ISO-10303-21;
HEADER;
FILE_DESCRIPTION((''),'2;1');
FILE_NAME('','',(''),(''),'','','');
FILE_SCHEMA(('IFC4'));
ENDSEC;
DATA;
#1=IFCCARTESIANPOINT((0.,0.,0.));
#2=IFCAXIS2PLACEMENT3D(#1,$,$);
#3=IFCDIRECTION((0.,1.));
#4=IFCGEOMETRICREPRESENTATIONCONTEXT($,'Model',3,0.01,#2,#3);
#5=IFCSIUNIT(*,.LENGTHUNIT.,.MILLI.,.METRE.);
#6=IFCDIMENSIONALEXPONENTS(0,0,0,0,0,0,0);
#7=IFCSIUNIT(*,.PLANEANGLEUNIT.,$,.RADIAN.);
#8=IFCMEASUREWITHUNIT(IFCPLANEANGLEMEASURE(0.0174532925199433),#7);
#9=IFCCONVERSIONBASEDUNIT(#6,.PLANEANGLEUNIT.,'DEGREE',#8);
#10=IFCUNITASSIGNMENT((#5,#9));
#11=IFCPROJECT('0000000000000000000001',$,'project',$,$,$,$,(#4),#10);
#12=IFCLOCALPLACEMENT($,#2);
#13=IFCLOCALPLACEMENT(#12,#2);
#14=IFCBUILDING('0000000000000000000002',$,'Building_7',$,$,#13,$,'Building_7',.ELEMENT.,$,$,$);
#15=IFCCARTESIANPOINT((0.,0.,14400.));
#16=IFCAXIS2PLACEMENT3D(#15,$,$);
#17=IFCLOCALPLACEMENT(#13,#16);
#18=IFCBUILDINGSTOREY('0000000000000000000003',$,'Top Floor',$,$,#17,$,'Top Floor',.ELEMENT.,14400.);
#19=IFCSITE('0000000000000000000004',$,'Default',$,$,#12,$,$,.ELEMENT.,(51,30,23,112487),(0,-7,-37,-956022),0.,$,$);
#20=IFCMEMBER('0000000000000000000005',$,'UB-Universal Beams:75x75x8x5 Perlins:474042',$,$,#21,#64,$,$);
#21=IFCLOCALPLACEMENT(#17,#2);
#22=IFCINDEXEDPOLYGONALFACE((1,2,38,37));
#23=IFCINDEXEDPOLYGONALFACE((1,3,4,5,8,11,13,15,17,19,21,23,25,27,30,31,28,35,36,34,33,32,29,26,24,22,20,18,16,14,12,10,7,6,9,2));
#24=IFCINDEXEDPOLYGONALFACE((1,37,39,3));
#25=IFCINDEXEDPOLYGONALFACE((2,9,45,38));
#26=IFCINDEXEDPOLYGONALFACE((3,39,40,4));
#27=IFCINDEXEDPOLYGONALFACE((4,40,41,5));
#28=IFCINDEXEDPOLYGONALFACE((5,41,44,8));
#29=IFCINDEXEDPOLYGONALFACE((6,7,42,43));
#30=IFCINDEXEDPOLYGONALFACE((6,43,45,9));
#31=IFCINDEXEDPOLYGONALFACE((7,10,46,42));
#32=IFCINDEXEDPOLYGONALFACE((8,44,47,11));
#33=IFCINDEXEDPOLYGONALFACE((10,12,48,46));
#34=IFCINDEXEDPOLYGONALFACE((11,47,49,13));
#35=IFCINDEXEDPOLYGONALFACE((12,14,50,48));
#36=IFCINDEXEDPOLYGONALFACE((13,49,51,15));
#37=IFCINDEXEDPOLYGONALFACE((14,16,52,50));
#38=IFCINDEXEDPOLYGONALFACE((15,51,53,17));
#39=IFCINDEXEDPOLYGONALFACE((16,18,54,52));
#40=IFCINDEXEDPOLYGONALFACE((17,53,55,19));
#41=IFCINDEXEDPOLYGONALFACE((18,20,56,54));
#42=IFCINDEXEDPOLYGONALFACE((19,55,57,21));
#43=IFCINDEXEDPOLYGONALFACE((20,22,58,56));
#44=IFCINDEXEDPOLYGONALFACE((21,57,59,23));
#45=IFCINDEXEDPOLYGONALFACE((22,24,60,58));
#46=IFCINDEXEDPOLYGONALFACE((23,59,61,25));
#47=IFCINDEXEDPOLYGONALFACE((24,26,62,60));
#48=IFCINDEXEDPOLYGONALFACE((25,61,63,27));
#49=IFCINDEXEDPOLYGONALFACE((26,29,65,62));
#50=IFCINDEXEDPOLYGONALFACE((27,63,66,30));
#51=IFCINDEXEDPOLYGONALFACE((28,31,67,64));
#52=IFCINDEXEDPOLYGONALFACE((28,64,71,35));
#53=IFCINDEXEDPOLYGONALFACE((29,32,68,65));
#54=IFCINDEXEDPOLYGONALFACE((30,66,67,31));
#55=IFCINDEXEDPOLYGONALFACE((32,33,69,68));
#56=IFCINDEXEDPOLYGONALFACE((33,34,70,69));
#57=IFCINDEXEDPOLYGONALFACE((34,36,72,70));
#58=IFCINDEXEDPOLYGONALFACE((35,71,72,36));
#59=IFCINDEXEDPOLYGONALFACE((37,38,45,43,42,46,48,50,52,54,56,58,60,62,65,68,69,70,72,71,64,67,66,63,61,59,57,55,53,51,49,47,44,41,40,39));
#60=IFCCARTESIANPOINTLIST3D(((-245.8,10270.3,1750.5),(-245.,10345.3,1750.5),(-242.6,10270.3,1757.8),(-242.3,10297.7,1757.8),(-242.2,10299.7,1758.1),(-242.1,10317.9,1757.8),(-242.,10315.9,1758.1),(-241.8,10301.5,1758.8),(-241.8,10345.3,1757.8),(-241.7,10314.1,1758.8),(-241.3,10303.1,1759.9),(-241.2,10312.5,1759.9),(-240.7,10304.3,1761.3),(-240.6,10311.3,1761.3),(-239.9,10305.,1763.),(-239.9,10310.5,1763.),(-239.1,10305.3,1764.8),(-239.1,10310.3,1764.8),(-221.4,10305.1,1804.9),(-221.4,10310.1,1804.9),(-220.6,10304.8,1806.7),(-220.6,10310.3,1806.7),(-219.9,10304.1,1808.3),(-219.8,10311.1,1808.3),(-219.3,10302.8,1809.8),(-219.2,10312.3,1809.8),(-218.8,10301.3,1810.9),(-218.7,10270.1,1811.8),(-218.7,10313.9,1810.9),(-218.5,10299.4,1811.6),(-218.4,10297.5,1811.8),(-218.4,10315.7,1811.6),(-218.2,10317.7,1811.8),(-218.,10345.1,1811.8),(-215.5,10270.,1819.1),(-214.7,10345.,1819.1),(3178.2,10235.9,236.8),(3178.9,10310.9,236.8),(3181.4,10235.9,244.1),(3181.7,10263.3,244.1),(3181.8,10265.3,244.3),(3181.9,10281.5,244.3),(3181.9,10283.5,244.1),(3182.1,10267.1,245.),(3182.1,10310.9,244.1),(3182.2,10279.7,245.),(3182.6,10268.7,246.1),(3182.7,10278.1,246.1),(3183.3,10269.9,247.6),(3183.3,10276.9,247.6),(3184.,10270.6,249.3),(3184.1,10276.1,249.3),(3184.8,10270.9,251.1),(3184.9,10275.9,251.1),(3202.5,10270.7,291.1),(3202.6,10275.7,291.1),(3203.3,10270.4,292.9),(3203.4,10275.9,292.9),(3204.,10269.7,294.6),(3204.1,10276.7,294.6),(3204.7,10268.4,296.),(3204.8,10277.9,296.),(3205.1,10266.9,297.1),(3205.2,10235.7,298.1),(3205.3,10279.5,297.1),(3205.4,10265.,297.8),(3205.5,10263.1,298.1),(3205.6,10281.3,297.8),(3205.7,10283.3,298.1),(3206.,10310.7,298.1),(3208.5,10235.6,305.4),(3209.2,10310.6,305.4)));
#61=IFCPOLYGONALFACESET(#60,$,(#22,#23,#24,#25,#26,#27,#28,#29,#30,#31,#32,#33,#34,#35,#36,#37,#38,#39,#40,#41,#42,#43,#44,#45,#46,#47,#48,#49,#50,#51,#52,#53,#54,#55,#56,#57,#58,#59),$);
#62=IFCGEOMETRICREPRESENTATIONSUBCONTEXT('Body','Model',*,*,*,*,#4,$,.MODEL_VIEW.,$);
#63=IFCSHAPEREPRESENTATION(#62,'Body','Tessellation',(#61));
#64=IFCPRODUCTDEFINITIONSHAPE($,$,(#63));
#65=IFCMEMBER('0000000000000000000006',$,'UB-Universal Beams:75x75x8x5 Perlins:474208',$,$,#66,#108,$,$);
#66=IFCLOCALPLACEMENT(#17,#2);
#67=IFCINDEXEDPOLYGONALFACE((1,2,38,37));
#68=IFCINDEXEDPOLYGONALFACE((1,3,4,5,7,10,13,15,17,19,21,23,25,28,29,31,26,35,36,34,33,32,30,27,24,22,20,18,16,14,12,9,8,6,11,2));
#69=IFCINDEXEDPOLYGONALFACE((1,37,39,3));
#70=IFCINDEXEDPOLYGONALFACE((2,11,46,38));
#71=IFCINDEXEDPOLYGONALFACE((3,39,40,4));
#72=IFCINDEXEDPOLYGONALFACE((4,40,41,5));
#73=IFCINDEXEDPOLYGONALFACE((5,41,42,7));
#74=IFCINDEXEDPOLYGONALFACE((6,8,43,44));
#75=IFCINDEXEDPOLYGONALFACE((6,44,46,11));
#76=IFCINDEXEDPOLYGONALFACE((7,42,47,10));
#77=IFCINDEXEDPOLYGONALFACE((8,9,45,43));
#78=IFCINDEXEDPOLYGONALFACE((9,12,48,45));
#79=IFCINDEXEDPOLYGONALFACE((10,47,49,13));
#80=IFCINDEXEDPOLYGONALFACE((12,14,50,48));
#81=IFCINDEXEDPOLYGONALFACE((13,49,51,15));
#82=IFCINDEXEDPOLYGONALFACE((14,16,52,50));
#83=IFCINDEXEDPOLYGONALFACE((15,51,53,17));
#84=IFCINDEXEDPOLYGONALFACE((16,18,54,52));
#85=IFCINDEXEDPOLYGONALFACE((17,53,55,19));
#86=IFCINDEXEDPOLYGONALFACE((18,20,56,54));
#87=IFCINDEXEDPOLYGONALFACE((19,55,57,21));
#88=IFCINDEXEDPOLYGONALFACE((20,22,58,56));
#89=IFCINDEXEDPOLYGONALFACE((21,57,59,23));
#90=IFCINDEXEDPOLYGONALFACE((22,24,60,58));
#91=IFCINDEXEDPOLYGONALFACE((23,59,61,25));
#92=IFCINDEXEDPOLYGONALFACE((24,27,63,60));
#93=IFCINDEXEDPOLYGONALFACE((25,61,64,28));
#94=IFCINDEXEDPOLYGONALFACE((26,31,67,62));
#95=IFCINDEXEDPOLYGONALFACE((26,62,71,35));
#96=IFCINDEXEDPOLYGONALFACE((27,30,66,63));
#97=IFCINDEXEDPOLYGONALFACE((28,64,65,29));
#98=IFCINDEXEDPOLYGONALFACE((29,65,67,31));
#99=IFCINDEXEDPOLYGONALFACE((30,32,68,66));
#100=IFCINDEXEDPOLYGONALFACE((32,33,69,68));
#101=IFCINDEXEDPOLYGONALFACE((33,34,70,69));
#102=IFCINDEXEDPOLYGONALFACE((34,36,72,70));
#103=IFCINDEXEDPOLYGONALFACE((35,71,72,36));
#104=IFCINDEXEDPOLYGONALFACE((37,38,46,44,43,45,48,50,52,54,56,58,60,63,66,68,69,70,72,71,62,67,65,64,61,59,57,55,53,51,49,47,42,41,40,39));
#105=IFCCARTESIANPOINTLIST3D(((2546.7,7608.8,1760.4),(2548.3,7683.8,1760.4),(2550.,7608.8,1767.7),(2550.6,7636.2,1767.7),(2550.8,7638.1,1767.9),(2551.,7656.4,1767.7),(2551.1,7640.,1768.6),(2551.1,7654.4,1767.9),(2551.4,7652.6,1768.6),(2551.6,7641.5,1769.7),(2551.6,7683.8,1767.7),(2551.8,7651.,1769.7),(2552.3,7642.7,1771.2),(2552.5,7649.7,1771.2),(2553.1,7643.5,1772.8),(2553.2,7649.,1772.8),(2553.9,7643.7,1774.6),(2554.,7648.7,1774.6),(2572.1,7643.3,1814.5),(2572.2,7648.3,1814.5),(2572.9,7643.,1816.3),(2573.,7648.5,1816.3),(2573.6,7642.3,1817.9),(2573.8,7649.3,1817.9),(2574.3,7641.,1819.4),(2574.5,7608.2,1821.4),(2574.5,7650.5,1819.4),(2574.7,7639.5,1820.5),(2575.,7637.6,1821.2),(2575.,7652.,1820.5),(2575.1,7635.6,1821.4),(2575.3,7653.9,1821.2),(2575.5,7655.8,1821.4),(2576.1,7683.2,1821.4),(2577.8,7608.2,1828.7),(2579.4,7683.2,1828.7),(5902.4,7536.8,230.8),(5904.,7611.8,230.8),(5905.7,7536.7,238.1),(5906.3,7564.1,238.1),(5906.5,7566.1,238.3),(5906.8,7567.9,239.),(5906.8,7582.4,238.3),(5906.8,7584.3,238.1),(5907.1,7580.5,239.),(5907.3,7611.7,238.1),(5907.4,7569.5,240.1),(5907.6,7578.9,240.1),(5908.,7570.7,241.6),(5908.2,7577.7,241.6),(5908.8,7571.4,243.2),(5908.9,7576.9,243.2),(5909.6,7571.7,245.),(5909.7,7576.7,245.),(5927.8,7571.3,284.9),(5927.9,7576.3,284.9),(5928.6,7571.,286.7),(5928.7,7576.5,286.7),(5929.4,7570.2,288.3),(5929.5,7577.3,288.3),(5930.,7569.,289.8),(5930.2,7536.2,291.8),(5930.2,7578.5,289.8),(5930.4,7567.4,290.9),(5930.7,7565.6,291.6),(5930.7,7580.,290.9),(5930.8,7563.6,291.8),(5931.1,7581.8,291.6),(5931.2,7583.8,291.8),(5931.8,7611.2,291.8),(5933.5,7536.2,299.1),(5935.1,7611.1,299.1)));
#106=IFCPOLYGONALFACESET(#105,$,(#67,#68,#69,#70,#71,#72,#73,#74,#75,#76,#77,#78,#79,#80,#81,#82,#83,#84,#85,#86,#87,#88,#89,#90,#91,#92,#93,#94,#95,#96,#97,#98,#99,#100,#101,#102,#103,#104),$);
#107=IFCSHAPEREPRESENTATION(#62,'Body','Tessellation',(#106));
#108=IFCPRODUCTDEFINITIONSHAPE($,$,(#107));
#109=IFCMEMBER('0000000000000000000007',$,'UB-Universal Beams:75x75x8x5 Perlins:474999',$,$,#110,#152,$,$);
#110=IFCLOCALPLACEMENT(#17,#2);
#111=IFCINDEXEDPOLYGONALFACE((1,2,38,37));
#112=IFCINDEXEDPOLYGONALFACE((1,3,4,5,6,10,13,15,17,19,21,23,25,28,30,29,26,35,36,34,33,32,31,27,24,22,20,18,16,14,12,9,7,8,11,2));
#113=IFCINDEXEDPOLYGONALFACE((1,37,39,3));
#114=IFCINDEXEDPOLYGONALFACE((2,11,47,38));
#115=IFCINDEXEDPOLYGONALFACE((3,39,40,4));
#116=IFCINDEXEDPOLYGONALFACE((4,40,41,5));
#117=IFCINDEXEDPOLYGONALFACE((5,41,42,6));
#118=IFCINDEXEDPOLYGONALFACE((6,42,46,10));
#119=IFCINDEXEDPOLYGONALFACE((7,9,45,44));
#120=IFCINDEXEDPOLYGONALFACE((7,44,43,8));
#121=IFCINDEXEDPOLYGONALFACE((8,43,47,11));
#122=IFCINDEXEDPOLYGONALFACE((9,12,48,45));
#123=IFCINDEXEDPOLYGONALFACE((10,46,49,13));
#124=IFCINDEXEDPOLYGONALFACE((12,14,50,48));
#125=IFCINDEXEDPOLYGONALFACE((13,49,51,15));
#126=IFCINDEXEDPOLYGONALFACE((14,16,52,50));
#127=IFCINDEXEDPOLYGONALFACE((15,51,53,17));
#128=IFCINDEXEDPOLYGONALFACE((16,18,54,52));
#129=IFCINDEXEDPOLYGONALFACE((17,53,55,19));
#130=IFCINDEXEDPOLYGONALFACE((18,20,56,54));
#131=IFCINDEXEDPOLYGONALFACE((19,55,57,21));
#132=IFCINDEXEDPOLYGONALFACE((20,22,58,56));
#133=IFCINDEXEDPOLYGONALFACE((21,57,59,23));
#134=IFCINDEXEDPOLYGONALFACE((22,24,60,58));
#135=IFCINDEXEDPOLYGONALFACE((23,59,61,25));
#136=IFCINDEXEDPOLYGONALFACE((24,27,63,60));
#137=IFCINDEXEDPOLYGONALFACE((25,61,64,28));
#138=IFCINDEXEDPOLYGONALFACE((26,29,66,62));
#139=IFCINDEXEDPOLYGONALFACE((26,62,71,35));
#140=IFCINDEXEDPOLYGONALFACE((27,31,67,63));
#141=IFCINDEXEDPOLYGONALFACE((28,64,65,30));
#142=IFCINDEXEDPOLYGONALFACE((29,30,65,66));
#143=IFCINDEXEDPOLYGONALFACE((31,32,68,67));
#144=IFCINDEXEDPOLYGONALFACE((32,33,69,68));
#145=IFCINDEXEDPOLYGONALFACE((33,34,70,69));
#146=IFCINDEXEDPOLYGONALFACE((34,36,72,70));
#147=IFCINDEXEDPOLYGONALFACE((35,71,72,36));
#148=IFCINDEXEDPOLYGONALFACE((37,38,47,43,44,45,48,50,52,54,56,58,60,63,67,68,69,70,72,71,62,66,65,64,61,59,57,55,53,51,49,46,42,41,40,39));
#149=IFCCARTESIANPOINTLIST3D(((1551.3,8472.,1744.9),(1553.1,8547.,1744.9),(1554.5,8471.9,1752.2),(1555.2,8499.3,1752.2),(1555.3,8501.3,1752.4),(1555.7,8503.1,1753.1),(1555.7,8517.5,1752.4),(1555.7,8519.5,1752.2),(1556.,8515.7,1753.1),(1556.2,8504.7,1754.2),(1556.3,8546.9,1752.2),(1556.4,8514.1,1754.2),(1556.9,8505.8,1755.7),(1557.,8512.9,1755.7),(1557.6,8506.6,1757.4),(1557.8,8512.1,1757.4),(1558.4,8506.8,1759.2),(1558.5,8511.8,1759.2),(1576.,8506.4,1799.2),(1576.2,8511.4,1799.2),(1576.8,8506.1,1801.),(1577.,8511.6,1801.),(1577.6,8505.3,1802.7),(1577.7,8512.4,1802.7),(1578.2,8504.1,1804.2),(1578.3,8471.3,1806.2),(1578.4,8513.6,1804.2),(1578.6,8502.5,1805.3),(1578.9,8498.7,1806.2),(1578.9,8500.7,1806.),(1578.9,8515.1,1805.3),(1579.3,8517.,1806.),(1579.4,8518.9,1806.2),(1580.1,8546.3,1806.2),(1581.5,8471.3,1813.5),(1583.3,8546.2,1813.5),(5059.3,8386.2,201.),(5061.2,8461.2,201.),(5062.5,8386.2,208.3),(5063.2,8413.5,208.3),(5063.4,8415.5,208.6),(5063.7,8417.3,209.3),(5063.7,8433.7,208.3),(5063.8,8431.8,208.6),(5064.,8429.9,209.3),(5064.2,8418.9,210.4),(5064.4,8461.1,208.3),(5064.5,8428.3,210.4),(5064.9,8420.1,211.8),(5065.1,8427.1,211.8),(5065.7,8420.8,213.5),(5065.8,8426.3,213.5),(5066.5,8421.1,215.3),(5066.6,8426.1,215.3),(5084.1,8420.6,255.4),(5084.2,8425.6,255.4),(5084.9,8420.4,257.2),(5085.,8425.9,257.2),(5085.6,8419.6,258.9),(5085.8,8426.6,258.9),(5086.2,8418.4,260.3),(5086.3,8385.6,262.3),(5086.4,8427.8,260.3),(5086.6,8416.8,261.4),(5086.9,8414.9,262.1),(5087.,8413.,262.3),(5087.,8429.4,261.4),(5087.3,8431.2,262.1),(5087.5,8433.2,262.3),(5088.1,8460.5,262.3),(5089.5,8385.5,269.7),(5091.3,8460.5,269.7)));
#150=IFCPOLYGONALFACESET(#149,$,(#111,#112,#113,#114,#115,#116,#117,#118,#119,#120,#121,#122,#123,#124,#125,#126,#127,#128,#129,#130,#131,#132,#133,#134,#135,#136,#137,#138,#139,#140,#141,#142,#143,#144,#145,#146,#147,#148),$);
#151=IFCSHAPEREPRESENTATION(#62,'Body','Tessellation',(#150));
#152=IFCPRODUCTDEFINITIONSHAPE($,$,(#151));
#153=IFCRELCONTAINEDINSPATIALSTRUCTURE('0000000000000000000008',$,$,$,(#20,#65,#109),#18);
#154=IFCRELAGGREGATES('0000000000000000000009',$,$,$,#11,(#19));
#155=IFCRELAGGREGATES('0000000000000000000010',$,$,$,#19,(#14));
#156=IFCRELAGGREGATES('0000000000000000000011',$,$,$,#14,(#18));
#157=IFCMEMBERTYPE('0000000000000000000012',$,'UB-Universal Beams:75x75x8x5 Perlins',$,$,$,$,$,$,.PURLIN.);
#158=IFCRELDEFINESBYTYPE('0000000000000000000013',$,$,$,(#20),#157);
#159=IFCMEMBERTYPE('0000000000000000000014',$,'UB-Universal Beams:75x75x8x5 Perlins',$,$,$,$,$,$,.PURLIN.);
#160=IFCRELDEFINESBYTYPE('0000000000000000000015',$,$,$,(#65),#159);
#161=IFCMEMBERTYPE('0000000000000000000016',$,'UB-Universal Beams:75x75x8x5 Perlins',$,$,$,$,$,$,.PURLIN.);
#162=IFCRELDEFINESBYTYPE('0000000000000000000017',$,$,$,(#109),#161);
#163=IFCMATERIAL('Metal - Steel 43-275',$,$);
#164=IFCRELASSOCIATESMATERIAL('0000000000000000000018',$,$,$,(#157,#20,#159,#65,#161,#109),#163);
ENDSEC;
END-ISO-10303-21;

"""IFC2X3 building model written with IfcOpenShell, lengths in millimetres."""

from ifc_helpers import new_model, entity, si_unit, converted_unit, direction, frame, frame_2d, origin, place, context, subcontext, project, spatial, polyline, circle_curve, parameter, trimmed, segment, composite_curve, outline, extrude, source, transform, mapped, material, type_object, type_shapes, element, save


model = new_model("IFC2X3")

# Units and contexts
model_context = context("Model", 3, precision=0.01, world=origin(), true_north=direction((0.0, 1.0)))
body_context = subcontext(model_context, "Body", "Model", "MODEL_VIEW")
ifc_project = project(units=[si_unit("LENGTHUNIT", "METRE", prefix="MILLI"), converted_unit("PLANEANGLEUNIT", "DEGREE", entity("IfcPlaneAngleMeasure", 0.0174532925199433), si_unit("PLANEANGLEUNIT", "RADIAN"), dimensions=[0, 0, 0, 0, 0, 0, 0])], contexts=[model_context])

# Site, building, storey
site_placement = place(None, origin())
site = spatial("IfcSite", under=ifc_project, at=site_placement, Name="Default", CompositionType="ELEMENT", RefLatitude=(51, 30, 23, 112487), RefLongitude=(0, -7, -37, -956022), RefElevation=0.0)
building_placement = place(site_placement, origin())
building = spatial("IfcBuilding", under=site, at=building_placement, Name="Building_7", LongName="Building_7", CompositionType="ELEMENT")
storey_placement = place(building_placement, frame((0.0, 0.0, 14400.0)))
storey = spatial("IfcBuildingStorey", under=building, at=storey_placement, Name="Top Floor", LongName="Top Floor", CompositionType="ELEMENT", Elevation=14400.0)

# Members
ifc_material = material(Name="Metal - Steel 43-275")
member_type_1 = type_object("IfcMemberType", Name="UB-Universal Beams:75x75x8x5 Perlins", PredefinedType="PURLIN", material=ifc_material)
shared_shape_1 = source(origin(), body_context, "Body", "SweptSolid", [
    extrude(outline(composite_curve([segment(polyline([(-37.5, -29.5), (-37.5, -37.5)]), True, "CONTINUOUS"), segment(polyline([(-37.5, -37.5), (37.5, -37.5)]), True, "CONTINUOUS"), segment(polyline([(37.5, -37.5), (37.5, -29.5)]), True, "CONTINUOUS"), segment(polyline([(37.5, -29.5), (10.1, -29.5)]), True, "CONTINUOUS"), segment(trimmed(circle_curve(frame_2d((10.1, -21.9), x_axis=(1.0, 0.0)), 7.6), [parameter(180.0)], [parameter(270.0)], True, "PARAMETER"), False, "CONTINUOUS"), segment(polyline([(2.5, -21.9), (2.5, 21.9)]), True, "CONTINUOUS"), segment(trimmed(circle_curve(frame_2d((10.1, 21.9), x_axis=(1.0, 0.0)), 7.6), [parameter(90.0)], [parameter(180.0)], True, "PARAMETER"), False, "CONTINUOUS"), segment(polyline([(10.1, 29.5), (37.5, 29.5)]), True, "CONTINUOUS"), segment(polyline([(37.5, 29.5), (37.5, 37.5)]), True, "CONTINUOUS"), segment(polyline([(37.5, 37.5), (-37.5, 37.5)]), True, "CONTINUOUS"), segment(polyline([(-37.5, 37.5), (-37.5, 29.5)]), True, "CONTINUOUS"), segment(polyline([(-37.5, 29.5), (-10.1, 29.5)]), True, "CONTINUOUS"), segment(trimmed(circle_curve(frame_2d((-10.1, 21.9), x_axis=(1.0, 0.0)), 7.6), [parameter(360.0)], [parameter(90.0)], True, "PARAMETER"), False, "CONTINUOUS"), segment(polyline([(-2.5, 21.9), (-2.5, -21.9)]), True, "CONTINUOUS"), segment(trimmed(circle_curve(frame_2d((-10.1, -21.9), x_axis=(1.0, 0.0)), 7.6), [parameter(270.0)], [parameter(360.0)], True, "PARAMETER"), False, "CONTINUOUS"), segment(polyline([(-10.1, -29.5), (-37.5, -29.5)]), True, "CONTINUOUS")], self_intersect=False)), frame((-1865.2, 0.0, 0.0), z_axis=(-1.0, 0.0, 0.0), x_axis=(0.0, -1.0, 0.0)), (0.0, 0.0, -1.0), 3743.8),
])
type_shapes(member_type_1, [shared_shape_1])
member_1_placement = place(storey_placement, frame((1487.8, 10290.4, 1025.3), z_axis=(0.404312, -0.004061, 0.914612), x_axis=(-0.914566, 0.009187, 0.404332)))
element("IfcMember", 1, at=member_1_placement, inside=storey, type_object=member_type_1, material=ifc_material, Name="UB-Universal Beams:75x75x8x5 Perlins:474042", context=body_context, shape_type="MappedRepresentation", body=[
    mapped(shared_shape_1, transform((0.0, 0.0, 0.0), scale=1.0)),
])
member_type_2 = type_object("IfcMemberType", Name="UB-Universal Beams:75x75x8x5 Perlins", PredefinedType="PURLIN", material=ifc_material)
shared_shape_2 = source(origin(), body_context, "Body", "SweptSolid", [
    extrude(outline(composite_curve([segment(polyline([(-37.5, -29.5), (-37.5, -37.5)]), True, "CONTINUOUS"), segment(polyline([(-37.5, -37.5), (37.5, -37.5)]), True, "CONTINUOUS"), segment(polyline([(37.5, -37.5), (37.5, -29.5)]), True, "CONTINUOUS"), segment(polyline([(37.5, -29.5), (10.1, -29.5)]), True, "CONTINUOUS"), segment(trimmed(circle_curve(frame_2d((10.1, -21.9), x_axis=(1.0, 0.0)), 7.6), [parameter(180.0)], [parameter(270.0)], True, "PARAMETER"), False, "CONTINUOUS"), segment(polyline([(2.5, -21.9), (2.5, 21.9)]), True, "CONTINUOUS"), segment(trimmed(circle_curve(frame_2d((10.1, 21.9), x_axis=(1.0, 0.0)), 7.6), [parameter(90.0)], [parameter(180.0)], True, "PARAMETER"), False, "CONTINUOUS"), segment(polyline([(10.1, 29.5), (37.5, 29.5)]), True, "CONTINUOUS"), segment(polyline([(37.5, 29.5), (37.5, 37.5)]), True, "CONTINUOUS"), segment(polyline([(37.5, 37.5), (-37.5, 37.5)]), True, "CONTINUOUS"), segment(polyline([(-37.5, 37.5), (-37.5, 29.5)]), True, "CONTINUOUS"), segment(polyline([(-37.5, 29.5), (-10.1, 29.5)]), True, "CONTINUOUS"), segment(trimmed(circle_curve(frame_2d((-10.1, 21.9), x_axis=(1.0, 0.0)), 7.6), [parameter(360.0)], [parameter(90.0)], True, "PARAMETER"), False, "CONTINUOUS"), segment(polyline([(-2.5, 21.9), (-2.5, -21.9)]), True, "CONTINUOUS"), segment(trimmed(circle_curve(frame_2d((-10.1, -21.9), x_axis=(1.0, 0.0)), 7.6), [parameter(270.0)], [parameter(360.0)], True, "PARAMETER"), False, "CONTINUOUS"), segment(polyline([(-10.1, -29.5), (-37.5, -29.5)]), True, "CONTINUOUS")], self_intersect=False)), frame((-1762.7, 0.0, 0.0), z_axis=(-1.0, 0.0, 0.0), x_axis=(0.0, -1.0, 0.0)), (0.0, 0.0, -1.0), 3688.6),
])
type_shapes(member_type_2, [shared_shape_2])
member_2_placement = place(storey_placement, frame((4166.6, 7611.6, 1063.6), z_axis=(0.414589, -0.008899, 0.909965), x_axis=(0.909756, -0.019527, -0.414685)))
element("IfcMember", 2, at=member_2_placement, inside=storey, type_object=member_type_2, material=ifc_material, Name="UB-Universal Beams:75x75x8x5 Perlins:474208", context=body_context, shape_type="MappedRepresentation", body=[
    mapped(shared_shape_2, transform((0.0, 0.0, 0.0), scale=1.0)),
])
member_type_3 = type_object("IfcMemberType", Name="UB-Universal Beams:75x75x8x5 Perlins", PredefinedType="PURLIN", material=ifc_material)
shared_shape_3 = source(origin(), body_context, "Body", "SweptSolid", [
    extrude(outline(composite_curve([segment(polyline([(-37.5, -29.5), (-37.5, -37.5)]), True, "CONTINUOUS"), segment(polyline([(-37.5, -37.5), (37.5, -37.5)]), True, "CONTINUOUS"), segment(polyline([(37.5, -37.5), (37.5, -29.5)]), True, "CONTINUOUS"), segment(polyline([(37.5, -29.5), (10.1, -29.5)]), True, "CONTINUOUS"), segment(trimmed(circle_curve(frame_2d((10.1, -21.9), x_axis=(1.0, 0.0)), 7.6), [parameter(180.0)], [parameter(270.0)], True, "PARAMETER"), False, "CONTINUOUS"), segment(polyline([(2.5, -21.9), (2.5, 21.9)]), True, "CONTINUOUS"), segment(trimmed(circle_curve(frame_2d((10.1, 21.9), x_axis=(1.0, 0.0)), 7.6), [parameter(90.0)], [parameter(180.0)], True, "PARAMETER"), False, "CONTINUOUS"), segment(polyline([(10.1, 29.5), (37.5, 29.5)]), True, "CONTINUOUS"), segment(polyline([(37.5, 29.5), (37.5, 37.5)]), True, "CONTINUOUS"), segment(polyline([(37.5, 37.5), (-37.5, 37.5)]), True, "CONTINUOUS"), segment(polyline([(-37.5, 37.5), (-37.5, 29.5)]), True, "CONTINUOUS"), segment(polyline([(-37.5, 29.5), (-10.1, 29.5)]), True, "CONTINUOUS"), segment(trimmed(circle_curve(frame_2d((-10.1, 21.9), x_axis=(1.0, 0.0)), 7.6), [parameter(360.0)], [parameter(90.0)], True, "PARAMETER"), False, "CONTINUOUS"), segment(polyline([(-2.5, 21.9), (-2.5, -21.9)]), True, "CONTINUOUS"), segment(trimmed(circle_curve(frame_2d((-10.1, -21.9), x_axis=(1.0, 0.0)), 7.6), [parameter(270.0)], [parameter(360.0)], True, "PARAMETER"), False, "CONTINUOUS"), segment(polyline([(-10.1, -29.5), (-37.5, -29.5)]), True, "CONTINUOUS")], self_intersect=False)), frame((-1927.3, 0.0, 0.0), z_axis=(-1.0, 0.0, 0.0), x_axis=(0.0, -1.0, 0.0)), (0.0, 0.0, -1.0), 3833.7),
])
type_shapes(member_type_3, [shared_shape_3])
member_3_placement = place(storey_placement, frame((3311.8, 8466.5, 1011.5), z_axis=(0.402591, -0.009842, 0.915327), x_axis=(-0.915054, 0.022371, 0.402711)))
element("IfcMember", 3, at=member_3_placement, inside=storey, type_object=member_type_3, material=ifc_material, Name="UB-Universal Beams:75x75x8x5 Perlins:474999", context=body_context, shape_type="MappedRepresentation", body=[
    mapped(shared_shape_3, transform((0.0, 0.0, 0.0), scale=1.0)),
])

save(model, "model.ifc")
